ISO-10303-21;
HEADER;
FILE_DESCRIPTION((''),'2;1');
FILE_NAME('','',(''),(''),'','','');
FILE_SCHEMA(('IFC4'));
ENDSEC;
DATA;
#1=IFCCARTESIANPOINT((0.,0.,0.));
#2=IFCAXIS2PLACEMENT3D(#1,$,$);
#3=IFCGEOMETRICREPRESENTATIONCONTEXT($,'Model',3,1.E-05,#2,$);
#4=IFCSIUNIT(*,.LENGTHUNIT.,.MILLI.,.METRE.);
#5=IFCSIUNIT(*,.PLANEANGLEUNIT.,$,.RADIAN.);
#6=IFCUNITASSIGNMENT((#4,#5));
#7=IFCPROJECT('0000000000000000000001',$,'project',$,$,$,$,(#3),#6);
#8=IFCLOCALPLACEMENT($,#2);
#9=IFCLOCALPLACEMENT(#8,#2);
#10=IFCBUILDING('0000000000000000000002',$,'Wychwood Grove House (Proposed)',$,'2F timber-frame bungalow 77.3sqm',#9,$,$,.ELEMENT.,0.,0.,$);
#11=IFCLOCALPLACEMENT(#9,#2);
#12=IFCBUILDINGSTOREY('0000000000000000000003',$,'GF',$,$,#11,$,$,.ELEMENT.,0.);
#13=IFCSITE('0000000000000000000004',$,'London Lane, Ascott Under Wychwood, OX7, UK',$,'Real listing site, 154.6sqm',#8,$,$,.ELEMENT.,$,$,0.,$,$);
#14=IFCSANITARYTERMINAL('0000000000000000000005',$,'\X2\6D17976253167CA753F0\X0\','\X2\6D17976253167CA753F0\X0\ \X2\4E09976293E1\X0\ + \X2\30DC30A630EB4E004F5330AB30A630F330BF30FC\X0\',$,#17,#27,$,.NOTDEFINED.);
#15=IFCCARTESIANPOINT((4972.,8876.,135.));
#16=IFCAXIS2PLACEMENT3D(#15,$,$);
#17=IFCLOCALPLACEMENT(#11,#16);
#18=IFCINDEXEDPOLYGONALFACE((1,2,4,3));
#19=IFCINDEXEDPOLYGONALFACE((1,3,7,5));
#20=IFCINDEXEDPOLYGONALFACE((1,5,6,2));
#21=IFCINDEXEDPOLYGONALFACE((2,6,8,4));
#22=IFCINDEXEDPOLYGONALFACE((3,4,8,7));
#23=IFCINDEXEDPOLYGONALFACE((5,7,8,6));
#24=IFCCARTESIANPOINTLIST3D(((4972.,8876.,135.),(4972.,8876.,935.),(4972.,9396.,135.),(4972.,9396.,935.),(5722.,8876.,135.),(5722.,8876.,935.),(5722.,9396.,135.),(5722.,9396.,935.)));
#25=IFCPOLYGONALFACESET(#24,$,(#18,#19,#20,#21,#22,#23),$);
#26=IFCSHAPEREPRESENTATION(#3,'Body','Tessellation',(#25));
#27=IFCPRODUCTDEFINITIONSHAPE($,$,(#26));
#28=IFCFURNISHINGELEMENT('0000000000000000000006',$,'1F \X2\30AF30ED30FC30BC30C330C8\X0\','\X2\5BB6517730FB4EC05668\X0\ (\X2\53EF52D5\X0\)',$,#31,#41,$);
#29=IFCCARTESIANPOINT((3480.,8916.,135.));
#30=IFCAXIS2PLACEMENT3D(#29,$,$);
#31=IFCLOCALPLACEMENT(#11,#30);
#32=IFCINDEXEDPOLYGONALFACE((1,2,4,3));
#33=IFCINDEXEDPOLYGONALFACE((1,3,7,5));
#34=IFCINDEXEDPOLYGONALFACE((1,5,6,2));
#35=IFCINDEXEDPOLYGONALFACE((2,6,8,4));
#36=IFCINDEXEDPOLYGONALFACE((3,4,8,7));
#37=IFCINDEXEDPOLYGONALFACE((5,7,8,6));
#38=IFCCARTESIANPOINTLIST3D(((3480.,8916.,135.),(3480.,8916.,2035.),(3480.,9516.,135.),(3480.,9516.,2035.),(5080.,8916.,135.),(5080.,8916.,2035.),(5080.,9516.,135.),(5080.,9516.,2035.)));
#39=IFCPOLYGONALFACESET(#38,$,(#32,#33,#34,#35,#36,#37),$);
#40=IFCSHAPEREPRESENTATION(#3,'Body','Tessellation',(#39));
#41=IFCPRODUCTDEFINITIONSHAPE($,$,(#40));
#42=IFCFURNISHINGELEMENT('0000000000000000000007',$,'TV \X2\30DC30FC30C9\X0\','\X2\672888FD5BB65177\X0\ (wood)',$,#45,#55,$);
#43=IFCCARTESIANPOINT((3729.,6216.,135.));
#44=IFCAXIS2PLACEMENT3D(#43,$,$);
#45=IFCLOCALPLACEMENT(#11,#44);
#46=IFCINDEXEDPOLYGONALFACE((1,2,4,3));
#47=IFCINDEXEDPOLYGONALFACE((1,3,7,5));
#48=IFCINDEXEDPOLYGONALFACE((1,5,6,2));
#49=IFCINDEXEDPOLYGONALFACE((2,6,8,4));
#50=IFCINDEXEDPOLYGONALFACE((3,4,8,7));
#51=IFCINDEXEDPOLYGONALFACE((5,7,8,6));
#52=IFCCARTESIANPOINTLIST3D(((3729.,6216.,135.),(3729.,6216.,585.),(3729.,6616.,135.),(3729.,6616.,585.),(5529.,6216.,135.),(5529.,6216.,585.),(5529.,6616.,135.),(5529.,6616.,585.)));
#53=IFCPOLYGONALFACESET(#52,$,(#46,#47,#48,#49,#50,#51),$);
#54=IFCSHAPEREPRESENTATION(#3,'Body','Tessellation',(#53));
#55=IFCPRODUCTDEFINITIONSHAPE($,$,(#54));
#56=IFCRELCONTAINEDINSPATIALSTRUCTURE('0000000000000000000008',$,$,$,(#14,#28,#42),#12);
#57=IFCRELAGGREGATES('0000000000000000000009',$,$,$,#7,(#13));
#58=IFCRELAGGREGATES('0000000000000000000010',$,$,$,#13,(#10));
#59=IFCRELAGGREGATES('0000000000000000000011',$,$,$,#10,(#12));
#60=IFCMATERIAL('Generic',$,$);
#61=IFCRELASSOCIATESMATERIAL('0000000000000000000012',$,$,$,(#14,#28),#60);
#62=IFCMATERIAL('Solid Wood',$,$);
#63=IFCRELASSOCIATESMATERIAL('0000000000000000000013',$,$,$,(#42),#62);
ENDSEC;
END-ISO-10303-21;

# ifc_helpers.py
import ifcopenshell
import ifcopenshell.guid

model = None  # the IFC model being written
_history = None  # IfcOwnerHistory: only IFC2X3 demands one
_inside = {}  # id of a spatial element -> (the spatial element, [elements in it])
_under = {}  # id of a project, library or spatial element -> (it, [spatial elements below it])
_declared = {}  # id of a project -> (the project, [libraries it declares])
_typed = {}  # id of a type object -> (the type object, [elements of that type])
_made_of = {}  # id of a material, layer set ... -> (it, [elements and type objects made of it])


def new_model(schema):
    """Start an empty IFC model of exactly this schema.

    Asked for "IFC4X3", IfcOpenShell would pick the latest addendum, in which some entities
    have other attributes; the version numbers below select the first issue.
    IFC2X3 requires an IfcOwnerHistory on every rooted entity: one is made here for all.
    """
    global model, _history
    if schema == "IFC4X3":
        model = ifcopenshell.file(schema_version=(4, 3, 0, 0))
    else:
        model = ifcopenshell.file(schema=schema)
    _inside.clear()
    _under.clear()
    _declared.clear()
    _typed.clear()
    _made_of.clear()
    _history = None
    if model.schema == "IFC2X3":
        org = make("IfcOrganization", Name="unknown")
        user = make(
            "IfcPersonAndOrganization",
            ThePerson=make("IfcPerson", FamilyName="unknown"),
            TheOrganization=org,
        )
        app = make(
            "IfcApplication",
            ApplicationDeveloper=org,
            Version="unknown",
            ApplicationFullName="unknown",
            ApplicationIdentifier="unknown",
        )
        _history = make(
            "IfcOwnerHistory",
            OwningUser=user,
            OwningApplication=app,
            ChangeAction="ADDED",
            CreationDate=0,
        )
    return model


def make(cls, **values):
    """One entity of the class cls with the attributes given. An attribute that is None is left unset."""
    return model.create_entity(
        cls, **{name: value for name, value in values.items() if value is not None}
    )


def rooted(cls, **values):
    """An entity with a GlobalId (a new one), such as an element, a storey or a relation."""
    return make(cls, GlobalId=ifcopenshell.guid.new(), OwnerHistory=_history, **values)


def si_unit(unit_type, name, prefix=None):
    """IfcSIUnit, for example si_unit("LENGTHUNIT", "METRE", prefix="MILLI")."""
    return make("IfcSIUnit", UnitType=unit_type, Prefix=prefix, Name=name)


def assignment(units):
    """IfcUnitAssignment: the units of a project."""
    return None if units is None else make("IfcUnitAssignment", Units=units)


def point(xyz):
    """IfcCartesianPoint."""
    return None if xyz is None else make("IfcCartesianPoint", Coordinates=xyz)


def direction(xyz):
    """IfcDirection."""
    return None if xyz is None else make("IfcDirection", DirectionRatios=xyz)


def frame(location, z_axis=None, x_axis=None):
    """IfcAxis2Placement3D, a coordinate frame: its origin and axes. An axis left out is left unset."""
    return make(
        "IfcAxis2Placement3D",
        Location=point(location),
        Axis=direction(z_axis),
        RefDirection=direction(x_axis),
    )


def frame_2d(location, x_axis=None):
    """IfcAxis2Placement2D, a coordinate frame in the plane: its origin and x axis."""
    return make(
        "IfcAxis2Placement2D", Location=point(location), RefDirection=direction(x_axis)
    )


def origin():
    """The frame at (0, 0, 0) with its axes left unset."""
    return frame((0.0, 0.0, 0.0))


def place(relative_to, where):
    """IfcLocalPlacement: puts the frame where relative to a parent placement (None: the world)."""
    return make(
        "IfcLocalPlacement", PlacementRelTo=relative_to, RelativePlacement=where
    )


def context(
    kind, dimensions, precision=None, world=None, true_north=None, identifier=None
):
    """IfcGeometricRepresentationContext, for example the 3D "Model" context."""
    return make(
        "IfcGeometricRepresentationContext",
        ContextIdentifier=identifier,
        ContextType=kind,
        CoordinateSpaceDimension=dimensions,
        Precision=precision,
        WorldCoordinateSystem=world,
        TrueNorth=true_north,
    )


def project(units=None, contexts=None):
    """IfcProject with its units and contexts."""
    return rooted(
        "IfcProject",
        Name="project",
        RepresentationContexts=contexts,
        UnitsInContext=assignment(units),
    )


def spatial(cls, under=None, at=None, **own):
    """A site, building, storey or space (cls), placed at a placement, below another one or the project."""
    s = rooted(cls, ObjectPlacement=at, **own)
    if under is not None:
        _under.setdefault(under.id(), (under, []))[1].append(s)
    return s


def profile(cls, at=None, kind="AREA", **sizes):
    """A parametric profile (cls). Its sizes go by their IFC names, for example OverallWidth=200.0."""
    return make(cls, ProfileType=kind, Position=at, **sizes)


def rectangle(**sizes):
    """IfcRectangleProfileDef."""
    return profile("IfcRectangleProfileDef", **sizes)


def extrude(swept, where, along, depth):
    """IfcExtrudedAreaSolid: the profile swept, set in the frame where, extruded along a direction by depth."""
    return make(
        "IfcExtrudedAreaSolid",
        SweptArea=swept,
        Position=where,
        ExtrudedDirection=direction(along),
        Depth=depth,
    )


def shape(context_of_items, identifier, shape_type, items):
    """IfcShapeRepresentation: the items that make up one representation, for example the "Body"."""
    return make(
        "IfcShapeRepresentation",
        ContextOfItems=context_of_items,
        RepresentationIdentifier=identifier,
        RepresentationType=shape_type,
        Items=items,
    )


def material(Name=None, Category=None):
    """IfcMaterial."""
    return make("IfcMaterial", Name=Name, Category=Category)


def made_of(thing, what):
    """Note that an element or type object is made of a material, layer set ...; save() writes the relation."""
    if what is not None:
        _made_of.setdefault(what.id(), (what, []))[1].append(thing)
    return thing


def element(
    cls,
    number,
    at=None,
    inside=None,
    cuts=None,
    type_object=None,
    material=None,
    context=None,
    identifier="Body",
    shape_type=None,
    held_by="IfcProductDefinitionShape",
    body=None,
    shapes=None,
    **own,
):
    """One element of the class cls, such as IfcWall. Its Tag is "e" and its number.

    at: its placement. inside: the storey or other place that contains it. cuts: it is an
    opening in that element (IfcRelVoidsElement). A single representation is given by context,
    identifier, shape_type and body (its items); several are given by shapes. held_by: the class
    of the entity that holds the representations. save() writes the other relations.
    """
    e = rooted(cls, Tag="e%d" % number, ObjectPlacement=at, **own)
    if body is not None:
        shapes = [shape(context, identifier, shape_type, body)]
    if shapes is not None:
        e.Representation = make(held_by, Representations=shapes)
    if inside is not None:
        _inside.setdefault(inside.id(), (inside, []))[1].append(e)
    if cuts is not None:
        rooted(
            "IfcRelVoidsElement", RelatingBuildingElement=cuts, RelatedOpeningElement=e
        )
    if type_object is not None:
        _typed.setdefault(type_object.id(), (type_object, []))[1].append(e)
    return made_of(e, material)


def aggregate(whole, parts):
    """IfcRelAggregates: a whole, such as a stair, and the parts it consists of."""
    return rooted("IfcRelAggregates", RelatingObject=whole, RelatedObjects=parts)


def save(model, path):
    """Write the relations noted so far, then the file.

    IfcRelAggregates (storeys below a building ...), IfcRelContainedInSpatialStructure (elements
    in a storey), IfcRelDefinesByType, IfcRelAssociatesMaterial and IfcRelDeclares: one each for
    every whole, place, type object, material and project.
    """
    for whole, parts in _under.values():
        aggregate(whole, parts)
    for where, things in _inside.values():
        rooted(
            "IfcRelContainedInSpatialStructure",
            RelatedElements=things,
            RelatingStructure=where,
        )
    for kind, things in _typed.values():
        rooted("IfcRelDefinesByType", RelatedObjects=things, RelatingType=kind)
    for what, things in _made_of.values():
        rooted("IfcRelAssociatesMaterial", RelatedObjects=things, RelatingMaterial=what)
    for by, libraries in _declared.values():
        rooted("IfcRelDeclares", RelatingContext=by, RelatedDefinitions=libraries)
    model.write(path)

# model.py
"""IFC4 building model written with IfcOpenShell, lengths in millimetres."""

from ifc_helpers import new_model, si_unit, frame, frame_2d, origin, place, context, project, spatial, rectangle, extrude, material, element, save


model = new_model("IFC4")

# Units and contexts
model_context = context("Model", 3, precision=1e-05, world=origin())
ifc_project = project(units=[si_unit("LENGTHUNIT", "METRE", prefix="MILLI"), si_unit("PLANEANGLEUNIT", "RADIAN")], contexts=[model_context])

# Site, building, storey
site_placement = place(None, origin())
site = spatial("IfcSite", under=ifc_project, at=site_placement, Name="London Lane, Ascott Under Wychwood, OX7, UK", ObjectType="Real listing site, 154.6sqm", CompositionType="ELEMENT", RefElevation=0.0)
building_placement = place(site_placement, origin())
building = spatial("IfcBuilding", under=site, at=building_placement, Name="Wychwood Grove House (Proposed)", ObjectType="2F timber-frame bungalow 77.3sqm", CompositionType="ELEMENT", ElevationOfRefHeight=0.0, ElevationOfTerrain=0.0)
storey_placement = place(building_placement, origin())
storey = spatial("IfcBuildingStorey", under=building, at=storey_placement, Name="GF", CompositionType="ELEMENT", Elevation=0.0)

# Shared definitions
ifc_material_1 = material(Name="Solid Wood")

# Shared definitions
ifc_material_2 = material(Name="Generic")

# Sanitary terminal
sanitary_terminal_1_placement = place(storey_placement, frame((4972.0, 8876.0, 135.0)))
element("IfcSanitaryTerminal", 1, at=sanitary_terminal_1_placement, inside=storey, material=ifc_material_2, Name="洗面化粧台", Description="洗面化粧台 三面鏡 + ボウル一体カウンター", PredefinedType="NOTDEFINED", context=model_context, shape_type="SweptSolid", body=[
    extrude(rectangle(XDim=750.0, YDim=520.0, at=frame_2d((375.0, 260.0))), frame((4972.0, 8876.0, 135.0)), (0.0, 0.0, 1.0), 800.0),
])

# Furnishing elements
furnishing_1_placement = place(storey_placement, frame((3480.0, 8916.0, 135.0)))
element("IfcFurnishingElement", 2, at=furnishing_1_placement, inside=storey, material=ifc_material_2, Name="1F クローゼット", Description="家具・什器 (可動)", context=model_context, shape_type="SweptSolid", body=[
    extrude(rectangle(XDim=1600.0, YDim=600.0, at=frame_2d((800.0, 300.0))), frame((3480.0, 8916.0, 135.0)), (0.0, 0.0, 1.0), 1900.0),
])
furnishing_2_placement = place(storey_placement, frame((3729.0, 6216.0, 135.0)))
element("IfcFurnishingElement", 3, at=furnishing_2_placement, inside=storey, material=ifc_material_1, Name="TV ボード", Description="木製家具 (wood)", context=model_context, shape_type="SweptSolid", body=[
    extrude(rectangle(XDim=1800.0, YDim=400.0, at=frame_2d((900.0, 200.0))), frame((3729.0, 6216.0, 135.0)), (0.0, 0.0, 1.0), 450.0),
])

save(model, "model.ifc")
